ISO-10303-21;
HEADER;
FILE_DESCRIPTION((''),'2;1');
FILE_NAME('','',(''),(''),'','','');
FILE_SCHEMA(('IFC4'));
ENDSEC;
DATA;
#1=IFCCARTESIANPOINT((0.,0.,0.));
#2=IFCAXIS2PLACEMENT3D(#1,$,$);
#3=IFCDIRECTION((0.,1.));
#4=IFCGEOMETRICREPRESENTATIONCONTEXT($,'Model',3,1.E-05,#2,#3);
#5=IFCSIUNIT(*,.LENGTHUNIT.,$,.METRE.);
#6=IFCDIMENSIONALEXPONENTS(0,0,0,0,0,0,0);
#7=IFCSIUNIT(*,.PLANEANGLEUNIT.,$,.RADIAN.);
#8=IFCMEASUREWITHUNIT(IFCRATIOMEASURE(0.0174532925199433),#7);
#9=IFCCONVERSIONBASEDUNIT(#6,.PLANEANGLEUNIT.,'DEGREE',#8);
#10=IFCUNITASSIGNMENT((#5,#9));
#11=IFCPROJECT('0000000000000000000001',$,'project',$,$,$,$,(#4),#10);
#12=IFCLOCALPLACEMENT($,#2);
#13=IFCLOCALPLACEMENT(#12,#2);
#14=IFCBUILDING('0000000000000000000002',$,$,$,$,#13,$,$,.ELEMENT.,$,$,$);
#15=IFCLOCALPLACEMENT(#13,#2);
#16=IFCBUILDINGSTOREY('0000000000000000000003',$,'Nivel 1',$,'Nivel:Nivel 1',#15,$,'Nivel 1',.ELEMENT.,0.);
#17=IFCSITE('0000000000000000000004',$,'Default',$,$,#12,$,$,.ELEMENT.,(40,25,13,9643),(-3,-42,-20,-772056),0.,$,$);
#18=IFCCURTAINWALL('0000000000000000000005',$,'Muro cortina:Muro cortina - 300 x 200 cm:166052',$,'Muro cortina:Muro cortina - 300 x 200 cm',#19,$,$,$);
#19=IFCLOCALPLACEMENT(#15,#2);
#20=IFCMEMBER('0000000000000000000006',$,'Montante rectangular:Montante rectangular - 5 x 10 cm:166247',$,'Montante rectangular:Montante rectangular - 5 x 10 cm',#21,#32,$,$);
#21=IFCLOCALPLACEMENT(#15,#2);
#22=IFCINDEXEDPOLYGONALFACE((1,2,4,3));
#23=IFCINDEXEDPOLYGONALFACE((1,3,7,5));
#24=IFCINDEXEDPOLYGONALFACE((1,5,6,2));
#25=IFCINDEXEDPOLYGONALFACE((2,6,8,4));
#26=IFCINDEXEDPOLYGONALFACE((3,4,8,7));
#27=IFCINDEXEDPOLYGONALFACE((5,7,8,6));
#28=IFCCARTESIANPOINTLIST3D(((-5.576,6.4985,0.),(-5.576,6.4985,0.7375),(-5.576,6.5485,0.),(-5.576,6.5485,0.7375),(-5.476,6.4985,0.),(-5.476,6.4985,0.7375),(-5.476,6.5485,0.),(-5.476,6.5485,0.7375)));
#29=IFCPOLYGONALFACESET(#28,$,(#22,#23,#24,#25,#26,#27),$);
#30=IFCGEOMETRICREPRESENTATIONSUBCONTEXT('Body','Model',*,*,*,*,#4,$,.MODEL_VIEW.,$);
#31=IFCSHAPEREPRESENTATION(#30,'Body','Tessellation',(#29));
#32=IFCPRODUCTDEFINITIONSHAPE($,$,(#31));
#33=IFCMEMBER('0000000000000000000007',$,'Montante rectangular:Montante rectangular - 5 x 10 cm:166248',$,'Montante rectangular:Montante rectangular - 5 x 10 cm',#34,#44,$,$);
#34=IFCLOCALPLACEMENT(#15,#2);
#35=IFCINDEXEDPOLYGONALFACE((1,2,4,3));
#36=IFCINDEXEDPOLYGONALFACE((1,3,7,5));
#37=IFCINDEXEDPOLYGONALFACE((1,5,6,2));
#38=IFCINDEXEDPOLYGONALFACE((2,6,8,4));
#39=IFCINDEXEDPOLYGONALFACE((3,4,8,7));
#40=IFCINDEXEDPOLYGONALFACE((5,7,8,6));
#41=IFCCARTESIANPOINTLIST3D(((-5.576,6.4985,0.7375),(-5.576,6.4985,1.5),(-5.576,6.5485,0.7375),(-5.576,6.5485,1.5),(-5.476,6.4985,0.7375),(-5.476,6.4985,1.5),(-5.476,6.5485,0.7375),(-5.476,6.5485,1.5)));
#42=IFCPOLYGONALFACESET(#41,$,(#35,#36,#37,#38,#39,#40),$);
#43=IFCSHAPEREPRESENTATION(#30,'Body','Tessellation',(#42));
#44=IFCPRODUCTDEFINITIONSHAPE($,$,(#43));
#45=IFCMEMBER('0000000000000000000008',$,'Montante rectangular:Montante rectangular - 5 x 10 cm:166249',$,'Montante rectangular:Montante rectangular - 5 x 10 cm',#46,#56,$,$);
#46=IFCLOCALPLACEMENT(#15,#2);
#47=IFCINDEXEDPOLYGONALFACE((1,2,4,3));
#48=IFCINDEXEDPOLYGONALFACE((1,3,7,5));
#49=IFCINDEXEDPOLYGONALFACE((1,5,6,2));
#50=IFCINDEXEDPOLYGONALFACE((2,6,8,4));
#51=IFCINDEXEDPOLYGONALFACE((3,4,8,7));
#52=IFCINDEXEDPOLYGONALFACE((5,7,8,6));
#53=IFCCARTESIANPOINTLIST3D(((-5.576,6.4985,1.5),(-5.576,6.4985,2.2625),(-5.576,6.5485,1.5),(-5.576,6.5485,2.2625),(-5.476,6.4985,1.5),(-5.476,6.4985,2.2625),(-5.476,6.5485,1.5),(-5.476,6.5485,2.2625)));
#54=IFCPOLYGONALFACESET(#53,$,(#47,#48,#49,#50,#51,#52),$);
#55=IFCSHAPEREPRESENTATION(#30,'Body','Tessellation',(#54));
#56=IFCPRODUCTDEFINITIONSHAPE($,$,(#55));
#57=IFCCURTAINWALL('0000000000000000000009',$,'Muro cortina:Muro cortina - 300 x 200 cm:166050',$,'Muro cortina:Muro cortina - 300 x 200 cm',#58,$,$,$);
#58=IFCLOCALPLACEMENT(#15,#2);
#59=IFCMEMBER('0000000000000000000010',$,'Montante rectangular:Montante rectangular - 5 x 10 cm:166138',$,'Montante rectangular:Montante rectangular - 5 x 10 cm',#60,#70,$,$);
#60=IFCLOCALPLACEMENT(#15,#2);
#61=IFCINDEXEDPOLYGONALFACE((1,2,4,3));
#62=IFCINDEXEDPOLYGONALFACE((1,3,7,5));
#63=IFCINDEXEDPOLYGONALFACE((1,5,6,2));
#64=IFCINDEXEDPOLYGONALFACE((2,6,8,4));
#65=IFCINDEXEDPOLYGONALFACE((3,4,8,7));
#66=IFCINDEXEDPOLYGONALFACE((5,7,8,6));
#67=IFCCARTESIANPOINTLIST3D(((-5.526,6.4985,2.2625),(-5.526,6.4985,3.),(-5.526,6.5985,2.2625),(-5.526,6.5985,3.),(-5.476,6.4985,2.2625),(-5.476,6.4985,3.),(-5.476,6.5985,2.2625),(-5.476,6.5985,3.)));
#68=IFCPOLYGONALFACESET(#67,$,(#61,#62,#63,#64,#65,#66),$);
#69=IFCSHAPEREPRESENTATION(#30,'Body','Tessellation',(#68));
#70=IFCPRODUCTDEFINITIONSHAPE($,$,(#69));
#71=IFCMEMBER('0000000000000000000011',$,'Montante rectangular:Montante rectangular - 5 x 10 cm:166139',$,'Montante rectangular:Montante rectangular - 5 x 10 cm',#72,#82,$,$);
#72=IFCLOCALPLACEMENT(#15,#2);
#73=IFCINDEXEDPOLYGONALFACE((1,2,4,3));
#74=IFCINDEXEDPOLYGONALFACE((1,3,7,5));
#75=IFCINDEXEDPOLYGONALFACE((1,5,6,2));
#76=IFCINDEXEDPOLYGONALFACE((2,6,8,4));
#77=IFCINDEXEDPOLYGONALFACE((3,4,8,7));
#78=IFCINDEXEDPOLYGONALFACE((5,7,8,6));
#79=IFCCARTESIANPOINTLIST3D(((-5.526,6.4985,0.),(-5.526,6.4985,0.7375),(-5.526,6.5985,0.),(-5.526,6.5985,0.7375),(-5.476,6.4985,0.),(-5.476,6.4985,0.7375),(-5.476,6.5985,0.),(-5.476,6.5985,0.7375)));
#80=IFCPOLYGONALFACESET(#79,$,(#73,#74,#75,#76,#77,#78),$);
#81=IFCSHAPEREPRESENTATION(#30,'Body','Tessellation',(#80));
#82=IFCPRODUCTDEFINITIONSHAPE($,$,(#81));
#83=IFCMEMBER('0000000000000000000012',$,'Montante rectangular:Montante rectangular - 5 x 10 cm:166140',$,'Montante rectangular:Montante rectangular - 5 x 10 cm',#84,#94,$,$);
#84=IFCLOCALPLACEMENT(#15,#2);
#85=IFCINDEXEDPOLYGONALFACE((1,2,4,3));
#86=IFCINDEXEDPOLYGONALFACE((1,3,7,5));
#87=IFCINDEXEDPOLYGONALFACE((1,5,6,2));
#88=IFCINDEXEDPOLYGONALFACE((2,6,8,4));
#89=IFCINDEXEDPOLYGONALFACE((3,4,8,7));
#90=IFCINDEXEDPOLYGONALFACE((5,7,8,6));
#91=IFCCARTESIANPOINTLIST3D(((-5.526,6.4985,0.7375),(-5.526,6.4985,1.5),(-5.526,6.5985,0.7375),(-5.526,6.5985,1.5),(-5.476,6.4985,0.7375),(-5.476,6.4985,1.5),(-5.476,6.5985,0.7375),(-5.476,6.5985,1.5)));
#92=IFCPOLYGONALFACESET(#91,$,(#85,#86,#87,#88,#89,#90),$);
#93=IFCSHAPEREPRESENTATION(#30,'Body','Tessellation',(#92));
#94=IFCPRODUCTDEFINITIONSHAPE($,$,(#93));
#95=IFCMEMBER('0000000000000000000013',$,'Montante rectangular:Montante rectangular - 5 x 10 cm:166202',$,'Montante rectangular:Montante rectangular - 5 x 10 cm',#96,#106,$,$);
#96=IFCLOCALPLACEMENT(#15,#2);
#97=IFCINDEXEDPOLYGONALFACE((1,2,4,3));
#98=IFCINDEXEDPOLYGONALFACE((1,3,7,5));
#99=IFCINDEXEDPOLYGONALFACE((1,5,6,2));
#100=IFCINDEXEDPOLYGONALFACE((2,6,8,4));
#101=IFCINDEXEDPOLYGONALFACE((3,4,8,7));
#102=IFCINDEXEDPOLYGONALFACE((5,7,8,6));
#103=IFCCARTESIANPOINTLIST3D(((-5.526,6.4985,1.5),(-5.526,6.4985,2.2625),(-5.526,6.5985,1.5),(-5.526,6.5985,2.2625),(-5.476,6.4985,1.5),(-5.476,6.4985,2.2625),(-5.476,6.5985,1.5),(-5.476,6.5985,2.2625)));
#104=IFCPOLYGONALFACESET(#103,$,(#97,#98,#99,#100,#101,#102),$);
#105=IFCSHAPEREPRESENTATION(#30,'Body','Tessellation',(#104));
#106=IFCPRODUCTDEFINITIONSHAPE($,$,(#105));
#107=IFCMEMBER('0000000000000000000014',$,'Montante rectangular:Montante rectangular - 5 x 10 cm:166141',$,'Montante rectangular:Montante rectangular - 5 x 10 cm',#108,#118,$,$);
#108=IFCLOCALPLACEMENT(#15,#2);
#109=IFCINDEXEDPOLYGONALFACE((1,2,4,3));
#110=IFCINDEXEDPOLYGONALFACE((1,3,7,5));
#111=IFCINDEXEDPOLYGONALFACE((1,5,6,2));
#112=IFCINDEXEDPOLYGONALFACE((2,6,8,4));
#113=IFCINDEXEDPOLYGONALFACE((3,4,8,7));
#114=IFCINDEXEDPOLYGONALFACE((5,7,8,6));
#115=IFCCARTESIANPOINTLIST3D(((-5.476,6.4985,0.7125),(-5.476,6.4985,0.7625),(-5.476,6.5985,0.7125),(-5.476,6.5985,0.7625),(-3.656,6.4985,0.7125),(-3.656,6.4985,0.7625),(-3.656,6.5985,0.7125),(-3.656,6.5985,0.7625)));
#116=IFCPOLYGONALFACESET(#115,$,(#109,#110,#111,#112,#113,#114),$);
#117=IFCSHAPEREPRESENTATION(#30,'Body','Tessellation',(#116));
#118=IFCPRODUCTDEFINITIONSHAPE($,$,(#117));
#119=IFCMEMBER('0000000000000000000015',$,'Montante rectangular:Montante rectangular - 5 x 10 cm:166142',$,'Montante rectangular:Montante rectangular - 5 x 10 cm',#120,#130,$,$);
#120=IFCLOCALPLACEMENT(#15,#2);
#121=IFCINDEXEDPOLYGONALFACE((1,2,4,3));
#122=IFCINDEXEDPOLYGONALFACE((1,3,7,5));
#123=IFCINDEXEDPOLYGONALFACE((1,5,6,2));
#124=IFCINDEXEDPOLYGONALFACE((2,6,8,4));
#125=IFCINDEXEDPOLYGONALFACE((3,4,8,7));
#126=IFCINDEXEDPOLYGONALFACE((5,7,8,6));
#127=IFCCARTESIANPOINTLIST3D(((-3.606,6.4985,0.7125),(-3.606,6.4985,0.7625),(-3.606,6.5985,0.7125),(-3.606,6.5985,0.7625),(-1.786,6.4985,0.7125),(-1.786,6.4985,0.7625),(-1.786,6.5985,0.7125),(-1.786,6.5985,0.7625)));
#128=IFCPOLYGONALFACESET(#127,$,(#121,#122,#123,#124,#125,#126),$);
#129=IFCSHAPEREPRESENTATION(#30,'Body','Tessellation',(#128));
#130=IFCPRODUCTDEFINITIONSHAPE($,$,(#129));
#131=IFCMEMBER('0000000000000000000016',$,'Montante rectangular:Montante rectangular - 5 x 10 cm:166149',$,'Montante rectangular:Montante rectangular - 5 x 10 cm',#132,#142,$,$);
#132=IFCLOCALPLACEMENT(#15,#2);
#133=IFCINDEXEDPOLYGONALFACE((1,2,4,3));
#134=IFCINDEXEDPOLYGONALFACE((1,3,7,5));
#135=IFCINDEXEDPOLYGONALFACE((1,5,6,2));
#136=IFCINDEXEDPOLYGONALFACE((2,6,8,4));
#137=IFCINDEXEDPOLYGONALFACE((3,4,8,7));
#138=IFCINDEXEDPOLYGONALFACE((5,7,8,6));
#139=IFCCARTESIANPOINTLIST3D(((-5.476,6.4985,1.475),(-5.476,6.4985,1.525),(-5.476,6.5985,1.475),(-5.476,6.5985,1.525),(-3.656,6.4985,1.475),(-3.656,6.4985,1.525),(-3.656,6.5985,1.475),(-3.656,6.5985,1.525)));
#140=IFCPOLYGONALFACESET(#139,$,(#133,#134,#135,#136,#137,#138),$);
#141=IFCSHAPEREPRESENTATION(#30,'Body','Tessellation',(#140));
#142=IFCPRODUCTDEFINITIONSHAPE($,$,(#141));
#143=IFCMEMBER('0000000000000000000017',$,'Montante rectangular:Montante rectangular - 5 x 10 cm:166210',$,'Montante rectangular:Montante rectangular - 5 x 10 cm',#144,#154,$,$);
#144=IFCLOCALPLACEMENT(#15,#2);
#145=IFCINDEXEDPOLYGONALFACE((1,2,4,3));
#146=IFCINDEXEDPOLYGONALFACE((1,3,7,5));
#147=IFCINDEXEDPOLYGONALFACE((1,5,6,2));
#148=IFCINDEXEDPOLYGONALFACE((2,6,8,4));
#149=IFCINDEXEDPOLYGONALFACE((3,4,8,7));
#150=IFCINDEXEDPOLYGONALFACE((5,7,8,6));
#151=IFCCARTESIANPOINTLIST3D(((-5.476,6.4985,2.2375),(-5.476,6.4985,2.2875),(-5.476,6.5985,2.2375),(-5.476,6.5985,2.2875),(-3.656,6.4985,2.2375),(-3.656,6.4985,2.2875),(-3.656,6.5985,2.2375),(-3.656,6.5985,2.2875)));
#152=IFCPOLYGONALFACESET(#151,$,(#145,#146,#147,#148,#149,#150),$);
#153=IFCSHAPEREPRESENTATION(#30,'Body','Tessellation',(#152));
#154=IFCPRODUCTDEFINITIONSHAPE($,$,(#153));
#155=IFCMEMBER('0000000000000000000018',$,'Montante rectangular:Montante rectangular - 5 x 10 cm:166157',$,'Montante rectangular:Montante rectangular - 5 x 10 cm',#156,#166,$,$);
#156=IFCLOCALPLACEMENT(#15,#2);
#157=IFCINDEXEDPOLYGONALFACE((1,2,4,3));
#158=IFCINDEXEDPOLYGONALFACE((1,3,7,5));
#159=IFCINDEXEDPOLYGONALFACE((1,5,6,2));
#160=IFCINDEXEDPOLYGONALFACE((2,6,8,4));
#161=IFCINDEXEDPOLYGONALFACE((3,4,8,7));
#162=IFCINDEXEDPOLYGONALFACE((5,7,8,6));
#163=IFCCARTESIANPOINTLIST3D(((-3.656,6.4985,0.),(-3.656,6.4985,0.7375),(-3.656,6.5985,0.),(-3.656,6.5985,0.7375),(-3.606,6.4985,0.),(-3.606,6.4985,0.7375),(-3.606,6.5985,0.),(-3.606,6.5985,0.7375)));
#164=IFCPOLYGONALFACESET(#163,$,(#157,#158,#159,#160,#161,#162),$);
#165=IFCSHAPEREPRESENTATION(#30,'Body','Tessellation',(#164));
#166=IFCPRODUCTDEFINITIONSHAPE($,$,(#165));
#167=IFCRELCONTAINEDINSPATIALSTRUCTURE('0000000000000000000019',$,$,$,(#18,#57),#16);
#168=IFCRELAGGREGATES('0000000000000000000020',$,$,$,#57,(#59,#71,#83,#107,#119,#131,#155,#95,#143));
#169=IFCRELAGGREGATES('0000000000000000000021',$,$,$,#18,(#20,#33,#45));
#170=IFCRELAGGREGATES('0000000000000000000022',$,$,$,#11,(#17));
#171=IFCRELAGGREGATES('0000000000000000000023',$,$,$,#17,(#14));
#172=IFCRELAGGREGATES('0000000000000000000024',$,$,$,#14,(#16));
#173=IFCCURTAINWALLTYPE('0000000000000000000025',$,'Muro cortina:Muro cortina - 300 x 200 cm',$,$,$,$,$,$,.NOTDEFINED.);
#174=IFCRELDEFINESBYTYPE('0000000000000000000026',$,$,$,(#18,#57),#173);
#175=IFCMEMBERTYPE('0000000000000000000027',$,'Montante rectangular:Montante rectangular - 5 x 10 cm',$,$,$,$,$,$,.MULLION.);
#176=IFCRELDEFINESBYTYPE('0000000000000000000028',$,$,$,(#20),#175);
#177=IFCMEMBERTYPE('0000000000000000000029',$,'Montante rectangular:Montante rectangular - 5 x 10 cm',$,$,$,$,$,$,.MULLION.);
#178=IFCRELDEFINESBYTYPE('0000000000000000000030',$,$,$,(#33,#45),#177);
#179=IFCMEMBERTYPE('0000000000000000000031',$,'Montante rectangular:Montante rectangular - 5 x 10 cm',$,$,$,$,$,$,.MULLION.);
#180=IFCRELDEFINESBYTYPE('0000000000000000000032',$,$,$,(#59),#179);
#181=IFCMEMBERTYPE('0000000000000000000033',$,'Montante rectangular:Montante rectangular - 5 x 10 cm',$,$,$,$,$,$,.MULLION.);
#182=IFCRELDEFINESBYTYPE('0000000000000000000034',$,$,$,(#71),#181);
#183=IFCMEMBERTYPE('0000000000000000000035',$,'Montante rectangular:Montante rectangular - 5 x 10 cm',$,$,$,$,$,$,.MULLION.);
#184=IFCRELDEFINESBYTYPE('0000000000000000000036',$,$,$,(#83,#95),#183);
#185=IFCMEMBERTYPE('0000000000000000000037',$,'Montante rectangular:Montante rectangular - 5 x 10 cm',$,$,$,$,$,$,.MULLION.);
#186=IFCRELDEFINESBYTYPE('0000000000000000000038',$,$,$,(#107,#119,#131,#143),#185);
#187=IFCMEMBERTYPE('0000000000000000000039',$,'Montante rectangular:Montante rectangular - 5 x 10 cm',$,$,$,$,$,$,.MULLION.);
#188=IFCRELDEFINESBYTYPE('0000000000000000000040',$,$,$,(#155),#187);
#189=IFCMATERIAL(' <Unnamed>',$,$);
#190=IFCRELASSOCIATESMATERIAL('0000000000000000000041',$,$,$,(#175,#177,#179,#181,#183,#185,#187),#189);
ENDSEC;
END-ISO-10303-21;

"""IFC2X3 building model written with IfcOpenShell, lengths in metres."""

from ifc_helpers import new_model, entity, si_unit, converted_unit, direction, frame, origin, origin_2d_with_axis, place, context, subcontext, project, spatial, rectangle, extrude, source, transform, mapped, material, type_object, type_shapes, element, aggregate, save


model = new_model("IFC2X3")

# Units and contexts
model_context = context("Model", 3, precision=1e-05, world=origin(), true_north=direction((0.0, 1.0)))
body_context = subcontext(model_context, "Body", "Model", "MODEL_VIEW")
ifc_project = project(units=[si_unit("LENGTHUNIT", "METRE"), converted_unit("PLANEANGLEUNIT", "DEGREE", entity("IfcRatioMeasure", 0.0174532925199433), si_unit("PLANEANGLEUNIT", "RADIAN"), dimensions=[0, 0, 0, 0, 0, 0, 0])], contexts=[model_context])

# Site, building, storey
site_placement = place(None, origin())
site = spatial("IfcSite", under=ifc_project, at=site_placement, Name="Default", CompositionType="ELEMENT", RefLatitude=(40, 25, 13, 9643), RefLongitude=(-3, -42, -20, -772056), RefElevation=0.0)
building_placement = place(site_placement, origin())
building = spatial("IfcBuilding", under=site, at=building_placement, CompositionType="ELEMENT")
storey_placement = place(building_placement, origin())
storey = spatial("IfcBuildingStorey", under=building, at=storey_placement, Name="Nivel 1", ObjectType="Nivel:Nivel 1", LongName="Nivel 1", CompositionType="ELEMENT", Elevation=0.0)

# Curtain walls, members
curtain_wall_type = type_object("IfcCurtainWallType", Name="Muro cortina:Muro cortina - 300 x 200 cm", PredefinedType="NOTDEFINED")
curtain_wall_1_placement = place(storey_placement, origin())
curtain_wall_1 = element("IfcCurtainWall", 1, at=curtain_wall_1_placement, inside=storey, type_object=curtain_wall_type, Name="Muro cortina:Muro cortina - 300 x 200 cm:166052", ObjectType="Muro cortina:Muro cortina - 300 x 200 cm")
ifc_material_1 = material(Name=" <Unnamed>")
member_type_1 = type_object("IfcMemberType", Name="Montante rectangular:Montante rectangular - 5 x 10 cm", PredefinedType="MULLION", material=ifc_material_1)
shared_shape_1 = source(origin(), body_context, "Body", "SweptSolid", [
    extrude(rectangle(XDim=0.1, YDim=0.05, at=origin_2d_with_axis()), frame((-0.025, 0.0, -0.7375), z_axis=(0.0, 0.0, 1.0), x_axis=(0.0, -1.0, 0.0)), (0.0, 0.0, 1.0), 0.7375),
])
type_shapes(member_type_1, [shared_shape_1])
member_1_placement = place(storey_placement, frame((-5.526, 6.5485, 0.0), z_axis=(0.0, 0.0, -1.0), x_axis=(0.0, 1.0, 0.0)))
member_1 = element("IfcMember", 2, at=member_1_placement, type_object=member_type_1, Name="Montante rectangular:Montante rectangular - 5 x 10 cm:166247", ObjectType="Montante rectangular:Montante rectangular - 5 x 10 cm", context=body_context, shape_type="MappedRepresentation", body=[
    mapped(shared_shape_1, transform((0.0, 0.0, 0.0), scale=1.0)),
])
member_type_2 = type_object("IfcMemberType", Name="Montante rectangular:Montante rectangular - 5 x 10 cm", PredefinedType="MULLION", material=ifc_material_1)
shared_shape_2 = source(origin(), body_context, "Body", "SweptSolid", [
    extrude(rectangle(XDim=0.1, YDim=0.05, at=origin_2d_with_axis()), frame((-0.025, 0.0, -0.7625), z_axis=(0.0, 0.0, 1.0), x_axis=(0.0, -1.0, 0.0)), (0.0, 0.0, 1.0), 0.7625),
])
type_shapes(member_type_2, [shared_shape_2])
member_2_placement = place(storey_placement, frame((-5.526, 6.5485, 0.7375), z_axis=(0.0, 0.0, -1.0), x_axis=(0.0, 1.0, 0.0)))
member_2 = element("IfcMember", 3, at=member_2_placement, type_object=member_type_2, Name="Montante rectangular:Montante rectangular - 5 x 10 cm:166248", ObjectType="Montante rectangular:Montante rectangular - 5 x 10 cm", context=body_context, shape_type="MappedRepresentation", body=[
    mapped(shared_shape_2, transform((0.0, 0.0, 0.0), scale=1.0)),
])
member_3_placement = place(storey_placement, frame((-5.526, 6.5485, 1.5), z_axis=(0.0, 0.0, -1.0), x_axis=(0.0, 1.0, 0.0)))
member_3 = element("IfcMember", 4, at=member_3_placement, type_object=member_type_2, Name="Montante rectangular:Montante rectangular - 5 x 10 cm:166249", ObjectType="Montante rectangular:Montante rectangular - 5 x 10 cm", context=body_context, shape_type="MappedRepresentation", body=[
    mapped(shared_shape_2, transform((0.0, 0.0, 0.0), scale=1.0)),
])
curtain_wall_2_placement = place(storey_placement, origin())
curtain_wall_2 = element("IfcCurtainWall", 5, at=curtain_wall_2_placement, inside=storey, type_object=curtain_wall_type, Name="Muro cortina:Muro cortina - 300 x 200 cm:166050", ObjectType="Muro cortina:Muro cortina - 300 x 200 cm")
member_type_3 = type_object("IfcMemberType", Name="Montante rectangular:Montante rectangular - 5 x 10 cm", PredefinedType="MULLION", material=ifc_material_1)
shared_shape_3 = source(origin(), body_context, "Body", "SweptSolid", [
    extrude(rectangle(XDim=0.1, YDim=0.05, at=origin_2d_with_axis()), frame((-0.025, 0.0, -0.7375), z_axis=(0.0, 0.0, 1.0), x_axis=(0.0, -1.0, 0.0)), (0.0, 0.0, 1.0), 0.7375),
])
type_shapes(member_type_3, [shared_shape_3])
member_4_placement = place(storey_placement, frame((-5.526, 6.5485, 3.0), z_axis=(0.0, 0.0, 1.0), x_axis=(-1.0, 0.0, 0.0)))
member_4 = element("IfcMember", 6, at=member_4_placement, type_object=member_type_3, Name="Montante rectangular:Montante rectangular - 5 x 10 cm:166138", ObjectType="Montante rectangular:Montante rectangular - 5 x 10 cm", context=body_context, shape_type="MappedRepresentation", body=[
    mapped(shared_shape_3, transform((0.0, 0.0, 0.0), scale=1.0)),
])
member_type_4 = type_object("IfcMemberType", Name="Montante rectangular:Montante rectangular - 5 x 10 cm", PredefinedType="MULLION", material=ifc_material_1)
shared_shape_4 = source(origin(), body_context, "Body", "SweptSolid", [
    extrude(rectangle(XDim=0.1, YDim=0.05, at=origin_2d_with_axis()), frame((-0.025, 0.0, -0.7375), z_axis=(0.0, 0.0, 1.0), x_axis=(0.0, -1.0, 0.0)), (0.0, 0.0, 1.0), 0.7375),
])
type_shapes(member_type_4, [shared_shape_4])
member_5_placement = place(storey_placement, frame((-5.526, 6.5485, 0.7375), z_axis=(0.0, 0.0, 1.0), x_axis=(-1.0, 0.0, 0.0)))
member_5 = element("IfcMember", 7, at=member_5_placement, type_object=member_type_4, Name="Montante rectangular:Montante rectangular - 5 x 10 cm:166139", ObjectType="Montante rectangular:Montante rectangular - 5 x 10 cm", context=body_context, shape_type="MappedRepresentation", body=[
    mapped(shared_shape_4, transform((0.0, 0.0, 0.0), scale=1.0)),
])
member_type_5 = type_object("IfcMemberType", Name="Montante rectangular:Montante rectangular - 5 x 10 cm", PredefinedType="MULLION", material=ifc_material_1)
shared_shape_5 = source(origin(), body_context, "Body", "SweptSolid", [
    extrude(rectangle(XDim=0.1, YDim=0.05, at=origin_2d_with_axis()), frame((-0.025, 0.0, -0.7625), z_axis=(0.0, 0.0, 1.0), x_axis=(0.0, -1.0, 0.0)), (0.0, 0.0, 1.0), 0.7625),
])
type_shapes(member_type_5, [shared_shape_5])
member_6_placement = place(storey_placement, frame((-5.526, 6.5485, 1.5), z_axis=(0.0, 0.0, 1.0), x_axis=(-1.0, 0.0, 0.0)))
member_6 = element("IfcMember", 8, at=member_6_placement, type_object=member_type_5, Name="Montante rectangular:Montante rectangular - 5 x 10 cm:166140", ObjectType="Montante rectangular:Montante rectangular - 5 x 10 cm", context=body_context, shape_type="MappedRepresentation", body=[
    mapped(shared_shape_5, transform((0.0, 0.0, 0.0), scale=1.0)),
])
member_7_placement = place(storey_placement, frame((-5.526, 6.5485, 2.2625), z_axis=(0.0, 0.0, 1.0), x_axis=(-1.0, 0.0, 0.0)))
member_7 = element("IfcMember", 9, at=member_7_placement, type_object=member_type_5, Name="Montante rectangular:Montante rectangular - 5 x 10 cm:166202", ObjectType="Montante rectangular:Montante rectangular - 5 x 10 cm", context=body_context, shape_type="MappedRepresentation", body=[
    mapped(shared_shape_5, transform((0.0, 0.0, 0.0), scale=1.0)),
])
member_type_6 = type_object("IfcMemberType", Name="Montante rectangular:Montante rectangular - 5 x 10 cm", PredefinedType="MULLION", material=ifc_material_1)
shared_shape_6 = source(origin(), body_context, "Body", "SweptSolid", [
    extrude(rectangle(XDim=0.1, YDim=0.05, at=origin_2d_with_axis()), frame((0.0, 0.0, -1.82), z_axis=(0.0, 0.0, 1.0), x_axis=(0.0, -1.0, 0.0)), (0.0, 0.0, 1.0), 1.82),
])
type_shapes(member_type_6, [shared_shape_6])
member_8_placement = place(storey_placement, frame((-3.656, 6.5485, 0.7375), z_axis=(1.0, 0.0, 0.0), x_axis=(0.0, 0.0, 1.0)))
member_8 = element("IfcMember", 10, at=member_8_placement, type_object=member_type_6, Name="Montante rectangular:Montante rectangular - 5 x 10 cm:166141", ObjectType="Montante rectangular:Montante rectangular - 5 x 10 cm", context=body_context, shape_type="MappedRepresentation", body=[
    mapped(shared_shape_6, transform((0.0, 0.0, 0.0), scale=1.0)),
])
member_9_placement = place(storey_placement, frame((-1.786, 6.5485, 0.7375), z_axis=(1.0, 0.0, 0.0), x_axis=(0.0, 0.0, 1.0)))
member_9 = element("IfcMember", 11, at=member_9_placement, type_object=member_type_6, Name="Montante rectangular:Montante rectangular - 5 x 10 cm:166142", ObjectType="Montante rectangular:Montante rectangular - 5 x 10 cm", context=body_context, shape_type="MappedRepresentation", body=[
    mapped(shared_shape_6, transform((0.0, 0.0, 0.0), scale=1.0)),
])
member_10_placement = place(storey_placement, frame((-3.656, 6.5485, 1.5), z_axis=(1.0, 0.0, 0.0), x_axis=(0.0, 0.0, 1.0)))
member_10 = element("IfcMember", 12, at=member_10_placement, type_object=member_type_6, Name="Montante rectangular:Montante rectangular - 5 x 10 cm:166149", ObjectType="Montante rectangular:Montante rectangular - 5 x 10 cm", context=body_context, shape_type="MappedRepresentation", body=[
    mapped(shared_shape_6, transform((0.0, 0.0, 0.0), scale=1.0)),
])
member_11_placement = place(storey_placement, frame((-3.656, 6.5485, 2.2625), z_axis=(1.0, 0.0, 0.0), x_axis=(0.0, 0.0, 1.0)))
member_11 = element("IfcMember", 13, at=member_11_placement, type_object=member_type_6, Name="Montante rectangular:Montante rectangular - 5 x 10 cm:166210", ObjectType="Montante rectangular:Montante rectangular - 5 x 10 cm", context=body_context, shape_type="MappedRepresentation", body=[
    mapped(shared_shape_6, transform((0.0, 0.0, 0.0), scale=1.0)),
])
member_type_7 = type_object("IfcMemberType", Name="Montante rectangular:Montante rectangular - 5 x 10 cm", PredefinedType="MULLION", material=ifc_material_1)
shared_shape_7 = source(origin(), body_context, "Body", "SweptSolid", [
    extrude(rectangle(XDim=0.1, YDim=0.05, at=origin_2d_with_axis()), frame((0.0, 0.0, -0.7375), z_axis=(0.0, 0.0, 1.0), x_axis=(0.0, -1.0, 0.0)), (0.0, 0.0, 1.0), 0.7375),
])
type_shapes(member_type_7, [shared_shape_7])
member_12_placement = place(storey_placement, frame((-3.631, 6.5485, 0.0), z_axis=(0.0, 0.0, -1.0), x_axis=(1.0, 0.0, 0.0)))
member_12 = element("IfcMember", 14, at=member_12_placement, type_object=member_type_7, Name="Montante rectangular:Montante rectangular - 5 x 10 cm:166157", ObjectType="Montante rectangular:Montante rectangular - 5 x 10 cm", context=body_context, shape_type="MappedRepresentation", body=[
    mapped(shared_shape_7, transform((0.0, 0.0, 0.0), scale=1.0)),
])

aggregate(curtain_wall_2, [member_4, member_5, member_6, member_8, member_9, member_10, member_12, member_7, member_11])
aggregate(curtain_wall_1, [member_1, member_2, member_3])

save(model, "model.ifc")
